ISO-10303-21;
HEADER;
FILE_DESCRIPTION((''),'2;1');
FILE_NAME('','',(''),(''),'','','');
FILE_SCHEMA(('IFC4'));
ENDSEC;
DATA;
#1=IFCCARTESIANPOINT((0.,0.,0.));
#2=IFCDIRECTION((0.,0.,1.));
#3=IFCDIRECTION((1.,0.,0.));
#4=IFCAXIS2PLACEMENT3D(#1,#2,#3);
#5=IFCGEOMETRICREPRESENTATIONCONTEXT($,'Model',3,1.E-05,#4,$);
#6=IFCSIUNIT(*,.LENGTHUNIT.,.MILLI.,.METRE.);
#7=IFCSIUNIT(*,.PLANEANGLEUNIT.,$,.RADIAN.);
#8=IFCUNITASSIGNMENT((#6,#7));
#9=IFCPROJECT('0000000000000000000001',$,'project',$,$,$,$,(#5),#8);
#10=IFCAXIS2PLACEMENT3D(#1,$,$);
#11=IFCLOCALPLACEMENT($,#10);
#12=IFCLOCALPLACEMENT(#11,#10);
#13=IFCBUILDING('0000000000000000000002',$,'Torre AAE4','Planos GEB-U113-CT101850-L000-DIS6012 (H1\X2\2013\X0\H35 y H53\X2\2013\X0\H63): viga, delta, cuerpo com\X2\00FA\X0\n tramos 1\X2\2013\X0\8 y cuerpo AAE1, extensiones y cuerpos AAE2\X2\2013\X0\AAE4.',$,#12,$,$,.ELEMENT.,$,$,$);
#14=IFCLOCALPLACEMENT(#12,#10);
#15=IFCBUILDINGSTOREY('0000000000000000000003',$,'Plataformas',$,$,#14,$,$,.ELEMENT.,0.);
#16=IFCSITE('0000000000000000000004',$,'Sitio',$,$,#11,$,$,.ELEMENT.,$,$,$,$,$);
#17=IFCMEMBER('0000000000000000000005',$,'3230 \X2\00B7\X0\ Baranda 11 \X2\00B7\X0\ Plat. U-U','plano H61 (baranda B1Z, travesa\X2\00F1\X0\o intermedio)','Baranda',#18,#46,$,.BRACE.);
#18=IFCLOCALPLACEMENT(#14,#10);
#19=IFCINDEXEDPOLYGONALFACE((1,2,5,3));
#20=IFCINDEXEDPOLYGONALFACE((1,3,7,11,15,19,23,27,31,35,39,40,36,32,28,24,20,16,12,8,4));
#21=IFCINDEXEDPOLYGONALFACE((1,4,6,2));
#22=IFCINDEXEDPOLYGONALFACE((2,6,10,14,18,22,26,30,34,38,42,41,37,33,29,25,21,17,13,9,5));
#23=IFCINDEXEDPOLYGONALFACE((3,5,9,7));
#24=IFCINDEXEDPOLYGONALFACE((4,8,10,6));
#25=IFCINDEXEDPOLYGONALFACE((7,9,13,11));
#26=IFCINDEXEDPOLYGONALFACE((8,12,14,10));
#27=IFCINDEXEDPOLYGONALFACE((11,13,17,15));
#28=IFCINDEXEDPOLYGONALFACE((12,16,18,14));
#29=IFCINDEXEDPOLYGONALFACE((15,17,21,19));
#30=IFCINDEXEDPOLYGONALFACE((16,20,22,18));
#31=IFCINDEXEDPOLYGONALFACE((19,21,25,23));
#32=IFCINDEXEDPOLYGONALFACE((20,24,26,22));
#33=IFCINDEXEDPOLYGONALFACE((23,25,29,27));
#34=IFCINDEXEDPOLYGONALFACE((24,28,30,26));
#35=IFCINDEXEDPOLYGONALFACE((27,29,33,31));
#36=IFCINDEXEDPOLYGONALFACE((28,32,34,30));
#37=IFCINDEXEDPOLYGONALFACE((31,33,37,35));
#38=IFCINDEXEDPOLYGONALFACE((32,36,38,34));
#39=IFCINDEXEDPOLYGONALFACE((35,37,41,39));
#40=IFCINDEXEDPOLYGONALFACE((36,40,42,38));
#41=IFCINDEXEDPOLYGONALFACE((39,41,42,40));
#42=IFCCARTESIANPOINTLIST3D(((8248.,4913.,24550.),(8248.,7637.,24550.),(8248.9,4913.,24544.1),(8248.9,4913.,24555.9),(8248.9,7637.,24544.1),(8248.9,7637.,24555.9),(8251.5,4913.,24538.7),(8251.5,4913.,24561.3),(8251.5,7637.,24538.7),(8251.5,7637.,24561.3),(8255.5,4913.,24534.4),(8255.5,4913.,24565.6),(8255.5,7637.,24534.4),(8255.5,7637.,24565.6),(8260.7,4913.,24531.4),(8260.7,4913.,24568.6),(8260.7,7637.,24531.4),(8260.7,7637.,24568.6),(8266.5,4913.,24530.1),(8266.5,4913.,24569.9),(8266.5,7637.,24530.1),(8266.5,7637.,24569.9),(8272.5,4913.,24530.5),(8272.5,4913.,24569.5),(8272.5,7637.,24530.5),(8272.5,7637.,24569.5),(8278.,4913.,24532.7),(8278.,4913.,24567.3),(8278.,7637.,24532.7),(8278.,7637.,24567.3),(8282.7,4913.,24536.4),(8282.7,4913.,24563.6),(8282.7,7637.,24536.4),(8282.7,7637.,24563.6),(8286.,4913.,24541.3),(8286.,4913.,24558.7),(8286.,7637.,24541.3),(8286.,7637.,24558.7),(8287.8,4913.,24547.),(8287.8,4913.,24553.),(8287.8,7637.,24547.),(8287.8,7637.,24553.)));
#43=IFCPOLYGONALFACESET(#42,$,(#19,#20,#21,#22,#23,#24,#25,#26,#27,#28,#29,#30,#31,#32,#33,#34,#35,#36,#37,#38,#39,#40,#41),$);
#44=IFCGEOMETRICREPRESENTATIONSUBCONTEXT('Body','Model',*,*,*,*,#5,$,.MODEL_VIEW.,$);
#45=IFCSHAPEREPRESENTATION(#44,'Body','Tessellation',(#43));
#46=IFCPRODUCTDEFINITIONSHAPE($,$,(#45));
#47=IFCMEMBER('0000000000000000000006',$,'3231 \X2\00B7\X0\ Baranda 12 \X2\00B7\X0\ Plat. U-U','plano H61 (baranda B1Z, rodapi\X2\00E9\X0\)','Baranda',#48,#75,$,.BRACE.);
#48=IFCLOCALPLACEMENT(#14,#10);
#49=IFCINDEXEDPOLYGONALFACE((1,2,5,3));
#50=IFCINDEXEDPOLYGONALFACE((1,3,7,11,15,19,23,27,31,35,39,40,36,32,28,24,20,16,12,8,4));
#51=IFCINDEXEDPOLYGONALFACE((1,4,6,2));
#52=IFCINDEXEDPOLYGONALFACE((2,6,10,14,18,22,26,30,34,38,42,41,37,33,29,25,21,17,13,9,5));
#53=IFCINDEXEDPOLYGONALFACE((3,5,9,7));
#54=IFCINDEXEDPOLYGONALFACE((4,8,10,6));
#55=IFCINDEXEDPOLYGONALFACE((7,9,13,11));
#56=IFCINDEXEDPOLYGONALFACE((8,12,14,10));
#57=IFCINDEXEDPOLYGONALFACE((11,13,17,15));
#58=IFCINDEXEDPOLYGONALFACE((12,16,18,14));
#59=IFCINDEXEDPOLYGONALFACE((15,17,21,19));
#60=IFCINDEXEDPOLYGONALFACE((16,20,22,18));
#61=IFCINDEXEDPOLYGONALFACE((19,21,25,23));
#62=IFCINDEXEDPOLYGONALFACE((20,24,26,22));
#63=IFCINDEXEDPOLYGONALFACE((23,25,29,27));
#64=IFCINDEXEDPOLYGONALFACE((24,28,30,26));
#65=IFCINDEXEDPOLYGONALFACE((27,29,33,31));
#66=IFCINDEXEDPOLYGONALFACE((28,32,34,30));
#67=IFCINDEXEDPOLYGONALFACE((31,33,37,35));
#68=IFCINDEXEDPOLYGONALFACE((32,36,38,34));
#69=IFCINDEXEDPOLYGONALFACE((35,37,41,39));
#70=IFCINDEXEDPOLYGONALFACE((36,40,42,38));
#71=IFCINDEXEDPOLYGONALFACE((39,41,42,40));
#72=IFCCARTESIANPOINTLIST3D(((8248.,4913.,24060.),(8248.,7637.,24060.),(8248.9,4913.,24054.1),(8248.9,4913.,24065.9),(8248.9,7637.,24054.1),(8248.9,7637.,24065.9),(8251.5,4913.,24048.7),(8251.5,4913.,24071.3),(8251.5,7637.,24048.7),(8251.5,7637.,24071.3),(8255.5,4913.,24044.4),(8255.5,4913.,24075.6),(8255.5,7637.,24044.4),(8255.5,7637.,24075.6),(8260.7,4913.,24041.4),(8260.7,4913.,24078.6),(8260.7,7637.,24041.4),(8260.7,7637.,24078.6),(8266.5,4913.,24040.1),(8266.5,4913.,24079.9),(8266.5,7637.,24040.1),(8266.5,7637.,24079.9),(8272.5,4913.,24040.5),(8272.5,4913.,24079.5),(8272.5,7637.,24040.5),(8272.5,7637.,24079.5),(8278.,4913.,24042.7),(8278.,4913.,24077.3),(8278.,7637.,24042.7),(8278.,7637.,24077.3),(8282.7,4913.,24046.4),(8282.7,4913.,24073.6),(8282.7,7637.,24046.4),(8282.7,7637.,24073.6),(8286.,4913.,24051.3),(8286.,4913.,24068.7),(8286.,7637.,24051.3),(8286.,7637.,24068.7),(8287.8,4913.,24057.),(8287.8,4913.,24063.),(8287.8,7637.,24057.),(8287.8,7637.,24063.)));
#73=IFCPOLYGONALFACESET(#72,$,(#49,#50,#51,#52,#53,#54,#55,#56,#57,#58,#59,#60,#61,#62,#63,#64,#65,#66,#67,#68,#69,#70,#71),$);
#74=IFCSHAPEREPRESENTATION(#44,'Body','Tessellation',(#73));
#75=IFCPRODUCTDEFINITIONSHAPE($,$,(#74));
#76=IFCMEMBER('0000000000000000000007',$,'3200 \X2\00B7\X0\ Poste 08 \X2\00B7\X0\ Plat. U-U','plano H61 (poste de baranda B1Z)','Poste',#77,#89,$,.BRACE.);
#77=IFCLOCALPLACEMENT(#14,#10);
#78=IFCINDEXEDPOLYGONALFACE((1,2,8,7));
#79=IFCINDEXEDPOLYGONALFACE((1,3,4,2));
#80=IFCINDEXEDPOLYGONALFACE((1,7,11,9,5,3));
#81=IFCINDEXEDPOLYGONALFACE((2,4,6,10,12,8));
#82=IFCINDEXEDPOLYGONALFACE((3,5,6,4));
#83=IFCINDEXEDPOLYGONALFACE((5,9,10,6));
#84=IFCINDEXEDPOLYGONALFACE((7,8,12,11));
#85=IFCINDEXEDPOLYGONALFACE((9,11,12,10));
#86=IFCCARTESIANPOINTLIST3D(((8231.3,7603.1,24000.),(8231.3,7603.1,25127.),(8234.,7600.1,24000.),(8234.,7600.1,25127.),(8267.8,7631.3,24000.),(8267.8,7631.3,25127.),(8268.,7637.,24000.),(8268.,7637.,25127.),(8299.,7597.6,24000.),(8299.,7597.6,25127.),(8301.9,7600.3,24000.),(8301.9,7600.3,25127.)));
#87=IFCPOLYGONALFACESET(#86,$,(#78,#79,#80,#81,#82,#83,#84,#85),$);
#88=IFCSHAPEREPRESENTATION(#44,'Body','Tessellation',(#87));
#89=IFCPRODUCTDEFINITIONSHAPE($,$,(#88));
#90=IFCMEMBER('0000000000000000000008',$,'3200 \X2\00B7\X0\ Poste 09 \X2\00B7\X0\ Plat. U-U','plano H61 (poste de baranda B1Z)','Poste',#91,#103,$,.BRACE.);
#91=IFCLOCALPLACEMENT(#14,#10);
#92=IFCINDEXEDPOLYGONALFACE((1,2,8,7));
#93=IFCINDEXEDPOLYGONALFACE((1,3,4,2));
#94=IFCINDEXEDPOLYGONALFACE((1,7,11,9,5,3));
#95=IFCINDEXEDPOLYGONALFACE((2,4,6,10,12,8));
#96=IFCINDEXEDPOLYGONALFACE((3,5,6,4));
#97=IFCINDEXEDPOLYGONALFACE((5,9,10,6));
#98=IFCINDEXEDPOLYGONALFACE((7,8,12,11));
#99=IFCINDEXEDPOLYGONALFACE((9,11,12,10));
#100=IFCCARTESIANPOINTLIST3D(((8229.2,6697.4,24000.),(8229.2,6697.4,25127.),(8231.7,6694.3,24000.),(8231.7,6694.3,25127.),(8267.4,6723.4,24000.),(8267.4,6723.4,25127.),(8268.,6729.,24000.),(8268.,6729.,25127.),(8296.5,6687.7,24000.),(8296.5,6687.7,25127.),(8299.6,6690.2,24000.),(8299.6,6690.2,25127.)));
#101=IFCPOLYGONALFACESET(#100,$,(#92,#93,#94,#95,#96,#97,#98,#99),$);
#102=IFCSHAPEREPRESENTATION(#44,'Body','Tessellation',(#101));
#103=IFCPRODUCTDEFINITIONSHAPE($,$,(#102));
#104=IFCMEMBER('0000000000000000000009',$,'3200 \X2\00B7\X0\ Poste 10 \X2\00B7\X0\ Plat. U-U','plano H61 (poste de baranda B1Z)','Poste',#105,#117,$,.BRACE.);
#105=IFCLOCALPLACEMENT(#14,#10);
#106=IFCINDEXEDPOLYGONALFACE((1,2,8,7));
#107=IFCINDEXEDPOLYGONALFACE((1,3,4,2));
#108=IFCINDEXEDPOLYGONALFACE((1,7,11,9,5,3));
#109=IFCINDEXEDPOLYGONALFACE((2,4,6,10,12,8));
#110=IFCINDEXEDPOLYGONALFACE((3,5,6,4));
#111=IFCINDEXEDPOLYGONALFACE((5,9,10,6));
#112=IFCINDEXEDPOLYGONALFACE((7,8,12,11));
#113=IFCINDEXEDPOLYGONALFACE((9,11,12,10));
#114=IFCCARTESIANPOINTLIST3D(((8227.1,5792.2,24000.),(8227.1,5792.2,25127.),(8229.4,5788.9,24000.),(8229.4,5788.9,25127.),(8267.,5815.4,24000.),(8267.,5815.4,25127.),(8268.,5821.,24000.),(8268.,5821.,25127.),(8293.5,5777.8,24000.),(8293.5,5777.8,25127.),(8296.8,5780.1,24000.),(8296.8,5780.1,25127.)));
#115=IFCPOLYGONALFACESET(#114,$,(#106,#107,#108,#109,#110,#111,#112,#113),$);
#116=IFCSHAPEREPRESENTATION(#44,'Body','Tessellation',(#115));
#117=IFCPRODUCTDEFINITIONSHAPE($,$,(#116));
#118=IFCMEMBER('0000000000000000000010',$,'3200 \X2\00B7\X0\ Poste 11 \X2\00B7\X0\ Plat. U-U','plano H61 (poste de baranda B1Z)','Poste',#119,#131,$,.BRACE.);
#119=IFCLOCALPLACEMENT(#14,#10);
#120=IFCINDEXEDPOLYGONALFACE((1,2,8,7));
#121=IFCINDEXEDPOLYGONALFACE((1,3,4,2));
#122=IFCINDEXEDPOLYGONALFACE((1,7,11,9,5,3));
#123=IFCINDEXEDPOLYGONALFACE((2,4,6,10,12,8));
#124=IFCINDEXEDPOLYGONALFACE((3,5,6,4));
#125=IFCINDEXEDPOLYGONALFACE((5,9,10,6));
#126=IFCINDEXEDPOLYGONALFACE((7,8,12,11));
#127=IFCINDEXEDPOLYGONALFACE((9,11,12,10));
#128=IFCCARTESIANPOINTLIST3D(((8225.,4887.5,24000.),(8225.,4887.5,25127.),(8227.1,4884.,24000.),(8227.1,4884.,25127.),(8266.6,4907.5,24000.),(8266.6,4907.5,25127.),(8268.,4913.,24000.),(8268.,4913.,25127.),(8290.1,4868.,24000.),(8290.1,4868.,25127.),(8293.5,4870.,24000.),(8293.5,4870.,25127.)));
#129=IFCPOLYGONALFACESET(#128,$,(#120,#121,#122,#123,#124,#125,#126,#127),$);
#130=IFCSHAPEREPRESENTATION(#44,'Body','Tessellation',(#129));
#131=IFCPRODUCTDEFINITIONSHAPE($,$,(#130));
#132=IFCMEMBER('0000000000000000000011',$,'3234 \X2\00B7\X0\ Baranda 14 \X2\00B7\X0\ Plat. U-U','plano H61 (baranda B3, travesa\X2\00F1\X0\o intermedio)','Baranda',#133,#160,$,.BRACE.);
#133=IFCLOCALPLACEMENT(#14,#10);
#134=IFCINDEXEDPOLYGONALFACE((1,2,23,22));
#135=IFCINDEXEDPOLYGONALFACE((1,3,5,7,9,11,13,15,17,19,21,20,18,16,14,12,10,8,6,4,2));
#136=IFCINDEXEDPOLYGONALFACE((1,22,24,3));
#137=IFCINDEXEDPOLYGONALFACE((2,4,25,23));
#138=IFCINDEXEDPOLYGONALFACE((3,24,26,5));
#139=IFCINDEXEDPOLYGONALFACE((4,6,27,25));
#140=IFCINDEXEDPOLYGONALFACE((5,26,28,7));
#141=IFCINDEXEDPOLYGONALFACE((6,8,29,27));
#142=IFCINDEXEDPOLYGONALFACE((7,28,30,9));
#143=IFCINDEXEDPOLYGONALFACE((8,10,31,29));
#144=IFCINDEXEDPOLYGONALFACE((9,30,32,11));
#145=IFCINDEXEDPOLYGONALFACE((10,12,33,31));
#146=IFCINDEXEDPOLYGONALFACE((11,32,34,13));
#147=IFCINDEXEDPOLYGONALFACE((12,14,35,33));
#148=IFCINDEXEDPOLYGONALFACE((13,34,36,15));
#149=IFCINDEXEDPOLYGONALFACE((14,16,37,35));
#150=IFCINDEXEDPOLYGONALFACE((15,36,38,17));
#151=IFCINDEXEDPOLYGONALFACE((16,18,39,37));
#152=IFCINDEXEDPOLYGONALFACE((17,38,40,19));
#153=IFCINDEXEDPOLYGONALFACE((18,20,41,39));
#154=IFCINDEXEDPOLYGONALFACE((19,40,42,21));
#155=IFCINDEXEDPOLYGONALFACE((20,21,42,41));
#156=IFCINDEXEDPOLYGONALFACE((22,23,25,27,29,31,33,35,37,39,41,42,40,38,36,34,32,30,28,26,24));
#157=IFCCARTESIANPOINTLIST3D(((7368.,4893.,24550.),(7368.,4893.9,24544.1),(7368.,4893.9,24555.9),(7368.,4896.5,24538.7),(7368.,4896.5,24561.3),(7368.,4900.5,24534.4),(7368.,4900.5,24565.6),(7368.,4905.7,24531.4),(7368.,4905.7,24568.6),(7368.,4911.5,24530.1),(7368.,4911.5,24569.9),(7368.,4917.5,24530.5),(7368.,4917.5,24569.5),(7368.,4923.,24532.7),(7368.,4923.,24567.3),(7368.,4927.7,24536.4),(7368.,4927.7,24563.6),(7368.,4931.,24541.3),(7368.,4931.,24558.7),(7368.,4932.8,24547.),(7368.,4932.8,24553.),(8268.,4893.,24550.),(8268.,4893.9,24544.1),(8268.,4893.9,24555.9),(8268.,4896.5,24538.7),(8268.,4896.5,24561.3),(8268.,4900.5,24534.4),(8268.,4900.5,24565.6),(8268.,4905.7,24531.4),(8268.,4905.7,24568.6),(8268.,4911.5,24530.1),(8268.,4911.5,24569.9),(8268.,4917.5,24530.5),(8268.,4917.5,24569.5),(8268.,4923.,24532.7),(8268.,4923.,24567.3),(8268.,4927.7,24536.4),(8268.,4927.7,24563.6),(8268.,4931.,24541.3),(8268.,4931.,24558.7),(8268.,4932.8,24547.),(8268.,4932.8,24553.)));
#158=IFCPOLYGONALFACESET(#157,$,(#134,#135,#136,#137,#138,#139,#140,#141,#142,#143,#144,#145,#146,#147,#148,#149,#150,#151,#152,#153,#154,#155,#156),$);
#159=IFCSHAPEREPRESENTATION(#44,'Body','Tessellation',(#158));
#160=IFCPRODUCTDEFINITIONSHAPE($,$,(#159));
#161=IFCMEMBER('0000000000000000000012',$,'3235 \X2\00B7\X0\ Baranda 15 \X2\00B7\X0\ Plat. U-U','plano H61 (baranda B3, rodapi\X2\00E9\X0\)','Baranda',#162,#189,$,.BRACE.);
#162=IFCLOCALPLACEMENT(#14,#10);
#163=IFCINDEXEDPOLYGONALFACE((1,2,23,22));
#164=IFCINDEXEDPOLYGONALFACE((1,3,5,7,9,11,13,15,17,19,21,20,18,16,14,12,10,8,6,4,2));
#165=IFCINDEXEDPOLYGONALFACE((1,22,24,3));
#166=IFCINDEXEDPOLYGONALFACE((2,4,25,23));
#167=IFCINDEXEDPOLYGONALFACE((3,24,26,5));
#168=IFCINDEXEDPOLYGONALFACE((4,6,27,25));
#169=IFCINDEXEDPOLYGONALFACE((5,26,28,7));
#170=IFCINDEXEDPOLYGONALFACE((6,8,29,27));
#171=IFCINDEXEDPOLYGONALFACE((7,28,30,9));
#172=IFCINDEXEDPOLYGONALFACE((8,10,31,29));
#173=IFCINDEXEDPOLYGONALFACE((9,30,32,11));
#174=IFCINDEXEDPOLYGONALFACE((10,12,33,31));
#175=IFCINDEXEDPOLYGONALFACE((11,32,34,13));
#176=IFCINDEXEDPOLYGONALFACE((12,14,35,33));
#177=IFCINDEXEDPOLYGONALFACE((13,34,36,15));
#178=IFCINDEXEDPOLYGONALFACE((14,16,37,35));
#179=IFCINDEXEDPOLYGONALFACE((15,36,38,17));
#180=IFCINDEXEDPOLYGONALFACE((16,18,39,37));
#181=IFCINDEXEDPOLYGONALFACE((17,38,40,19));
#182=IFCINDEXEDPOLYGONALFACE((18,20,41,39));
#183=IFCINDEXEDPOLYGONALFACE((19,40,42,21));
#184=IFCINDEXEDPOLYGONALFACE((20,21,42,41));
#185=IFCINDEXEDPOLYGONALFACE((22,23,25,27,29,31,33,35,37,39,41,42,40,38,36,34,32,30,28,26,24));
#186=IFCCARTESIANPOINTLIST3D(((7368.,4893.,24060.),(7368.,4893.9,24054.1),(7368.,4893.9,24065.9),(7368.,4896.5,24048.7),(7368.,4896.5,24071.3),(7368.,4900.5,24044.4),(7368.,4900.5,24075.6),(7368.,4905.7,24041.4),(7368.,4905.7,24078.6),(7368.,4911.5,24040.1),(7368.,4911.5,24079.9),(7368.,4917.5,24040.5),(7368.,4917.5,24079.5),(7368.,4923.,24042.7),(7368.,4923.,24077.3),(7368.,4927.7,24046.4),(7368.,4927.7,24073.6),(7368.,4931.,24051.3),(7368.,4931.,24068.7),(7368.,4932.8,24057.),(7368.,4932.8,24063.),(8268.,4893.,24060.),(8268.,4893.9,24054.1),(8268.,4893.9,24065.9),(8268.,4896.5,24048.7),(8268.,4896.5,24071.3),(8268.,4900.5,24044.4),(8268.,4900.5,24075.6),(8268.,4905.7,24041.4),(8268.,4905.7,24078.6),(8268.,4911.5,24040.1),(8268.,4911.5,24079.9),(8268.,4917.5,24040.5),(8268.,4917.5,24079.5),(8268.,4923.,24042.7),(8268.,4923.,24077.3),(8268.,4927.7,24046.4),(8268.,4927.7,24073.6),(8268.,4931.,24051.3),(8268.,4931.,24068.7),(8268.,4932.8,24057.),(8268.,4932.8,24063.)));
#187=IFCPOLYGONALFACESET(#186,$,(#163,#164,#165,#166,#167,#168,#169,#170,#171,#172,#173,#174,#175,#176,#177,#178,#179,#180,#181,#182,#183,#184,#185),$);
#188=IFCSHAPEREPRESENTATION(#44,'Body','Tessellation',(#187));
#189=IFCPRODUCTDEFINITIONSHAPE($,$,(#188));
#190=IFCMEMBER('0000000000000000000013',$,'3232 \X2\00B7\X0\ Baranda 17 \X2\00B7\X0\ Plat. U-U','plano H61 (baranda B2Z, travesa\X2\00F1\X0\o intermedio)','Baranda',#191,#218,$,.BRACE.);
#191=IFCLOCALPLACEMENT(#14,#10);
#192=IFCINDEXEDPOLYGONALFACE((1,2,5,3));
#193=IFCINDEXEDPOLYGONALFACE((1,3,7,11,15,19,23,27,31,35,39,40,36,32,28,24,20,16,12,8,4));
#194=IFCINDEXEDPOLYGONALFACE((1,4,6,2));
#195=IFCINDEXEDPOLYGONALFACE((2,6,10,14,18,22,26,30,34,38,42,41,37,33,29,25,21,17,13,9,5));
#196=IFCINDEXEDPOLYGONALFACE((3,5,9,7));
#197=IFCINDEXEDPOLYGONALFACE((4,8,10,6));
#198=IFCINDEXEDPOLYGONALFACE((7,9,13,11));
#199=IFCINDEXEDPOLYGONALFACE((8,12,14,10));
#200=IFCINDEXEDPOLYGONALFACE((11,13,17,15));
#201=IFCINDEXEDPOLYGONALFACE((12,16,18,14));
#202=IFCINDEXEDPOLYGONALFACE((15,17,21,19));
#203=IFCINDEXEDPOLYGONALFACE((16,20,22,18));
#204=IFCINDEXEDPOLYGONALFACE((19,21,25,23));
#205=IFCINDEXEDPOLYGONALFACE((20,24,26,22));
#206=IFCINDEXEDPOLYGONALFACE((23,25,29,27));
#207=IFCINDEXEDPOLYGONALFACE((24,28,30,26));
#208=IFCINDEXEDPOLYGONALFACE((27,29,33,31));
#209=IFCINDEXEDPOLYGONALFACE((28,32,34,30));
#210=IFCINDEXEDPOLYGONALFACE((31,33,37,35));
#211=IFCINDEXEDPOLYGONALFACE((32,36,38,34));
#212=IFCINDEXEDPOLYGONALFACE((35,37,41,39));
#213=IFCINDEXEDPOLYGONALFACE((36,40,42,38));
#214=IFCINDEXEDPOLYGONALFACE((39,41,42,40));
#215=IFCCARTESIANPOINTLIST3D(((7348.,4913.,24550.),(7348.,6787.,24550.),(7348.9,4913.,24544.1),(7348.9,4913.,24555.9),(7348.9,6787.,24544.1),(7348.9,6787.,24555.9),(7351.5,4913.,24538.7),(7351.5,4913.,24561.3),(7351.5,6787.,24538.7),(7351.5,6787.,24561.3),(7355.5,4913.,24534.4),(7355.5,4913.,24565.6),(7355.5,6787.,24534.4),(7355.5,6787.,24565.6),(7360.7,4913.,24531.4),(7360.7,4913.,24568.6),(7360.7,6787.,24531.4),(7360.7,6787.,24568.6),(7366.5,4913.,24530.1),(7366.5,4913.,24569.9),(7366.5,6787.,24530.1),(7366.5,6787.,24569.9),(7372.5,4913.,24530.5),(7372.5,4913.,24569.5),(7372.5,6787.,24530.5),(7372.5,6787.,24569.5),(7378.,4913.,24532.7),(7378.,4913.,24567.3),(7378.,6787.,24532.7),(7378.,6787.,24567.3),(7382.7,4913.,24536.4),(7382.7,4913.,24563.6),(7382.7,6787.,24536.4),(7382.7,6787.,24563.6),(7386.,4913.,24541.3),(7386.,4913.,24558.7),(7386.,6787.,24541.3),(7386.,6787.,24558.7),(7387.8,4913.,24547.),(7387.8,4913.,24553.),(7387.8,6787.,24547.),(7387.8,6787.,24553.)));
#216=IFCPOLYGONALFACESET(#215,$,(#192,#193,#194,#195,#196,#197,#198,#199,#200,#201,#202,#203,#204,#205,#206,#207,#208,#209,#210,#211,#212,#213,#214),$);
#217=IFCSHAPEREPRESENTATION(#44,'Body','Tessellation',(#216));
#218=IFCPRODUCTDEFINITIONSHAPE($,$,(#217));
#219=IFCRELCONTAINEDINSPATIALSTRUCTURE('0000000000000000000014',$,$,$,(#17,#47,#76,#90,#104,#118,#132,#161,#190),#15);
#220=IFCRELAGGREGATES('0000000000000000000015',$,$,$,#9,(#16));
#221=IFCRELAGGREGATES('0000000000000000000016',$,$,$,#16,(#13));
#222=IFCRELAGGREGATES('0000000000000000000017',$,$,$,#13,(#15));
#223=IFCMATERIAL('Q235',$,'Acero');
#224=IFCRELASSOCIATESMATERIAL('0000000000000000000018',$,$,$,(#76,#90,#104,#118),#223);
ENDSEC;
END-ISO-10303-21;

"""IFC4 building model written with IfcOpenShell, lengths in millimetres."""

from ifc_helpers import new_model, si_unit, frame, frame_2d, origin, origin_with_axes, place, context, subcontext, project, spatial, circle, l_section, extrude, material, element, save


model = new_model("IFC4")

# Units and contexts
model_context = context("Model", 3, precision=1e-05, world=origin_with_axes())
body_context = subcontext(model_context, "Body", "Model", "MODEL_VIEW")
ifc_project = project(units=[si_unit("LENGTHUNIT", "METRE", prefix="MILLI"), si_unit("PLANEANGLEUNIT", "RADIAN")], contexts=[model_context])

# Site, building, storey
site_placement = place(None, origin())
site = spatial("IfcSite", under=ifc_project, at=site_placement, Name="Sitio", CompositionType="ELEMENT")
building_placement = place(site_placement, origin())
building = spatial("IfcBuilding", under=site, at=building_placement, Name="Torre AAE4", Description="Planos GEB-U113-CT101850-L000-DIS6012 (H1–H35 y H53–H63): viga, delta, cuerpo común tramos 1–8 y cuerpo AAE1, extensiones y cuerpos AAE2–AAE4.", CompositionType="ELEMENT")
storey_placement = place(building_placement, origin())
storey = spatial("IfcBuildingStorey", under=building, at=storey_placement, Name="Plataformas", CompositionType="ELEMENT", Elevation=0.0)

# Members
ifc_material = material(Name="Q235", Category="Acero")
for number, where, z_axis, x_axis, name, description in (
    (1, (8268.0, 7637.0, 24550.0), (0.0, -1.0, 0.0), (-1.0, 0.0, 0.0), "3230 · Baranda 11 · Plat. U-U", "plano H61 (baranda B1Z, travesaño intermedio)"),
    (2, (8268.0, 7637.0, 24060.0), (0.0, -1.0, 0.0), (-1.0, 0.0, 0.0), "3231 · Baranda 12 · Plat. U-U", "plano H61 (baranda B1Z, rodapié)"),
):
    element("IfcMember", number, at=place(storey_placement, frame(where, z_axis=z_axis, x_axis=x_axis)), inside=storey, Name=name, Description=description, ObjectType="Baranda", PredefinedType="BRACE", context=body_context, shape_type="SweptSolid", body=[
        extrude(circle(Radius=20.0), None, (0.0, 0.0, 1.0), 2724.0),
    ])
for number, where, z_axis, x_axis, name in (
    (3, (8268.0, 7637.0, 24000.0), (0.0, 0.0, 1.0), (-0.734582, -0.67852, 0.0), "3200 · Poste 08 · Plat. U-U"),
    (4, (8268.0, 6729.0, 24000.0), (0.0, 0.0, 1.0), (-0.775597, -0.631228, 0.0), "3200 · Poste 09 · Plat. U-U"),
    (5, (8268.0, 5821.0, 24000.0), (0.0, 0.0, 1.0), (-0.817677, -0.575677, 0.0), "3200 · Poste 10 · Plat. U-U"),
    (6, (8268.0, 4913.0, 24000.0), (0.0, 0.0, 1.0), (-0.859678, -0.510837, 0.0), "3200 · Poste 11 · Plat. U-U"),
):
    element("IfcMember", number, at=place(storey_placement, frame(where, z_axis=z_axis, x_axis=x_axis)), inside=storey, material=ifc_material, Name=name, Description="plano H61 (poste de baranda B1Z)", ObjectType="Poste", PredefinedType="BRACE", context=body_context, shape_type="SweptSolid", body=[
        extrude(l_section(Depth=50.0, Width=50.0, Thickness=4.0, at=frame_2d((25.0, 25.0))), None, (0.0, 0.0, 1.0), 1127.0),
    ])
for number, where, z_axis, x_axis, name, description in (
    (7, (8268.0, 4913.0, 24550.0), (-1.0, 0.0, 0.0), (0.0, -1.0, 0.0), "3234 · Baranda 14 · Plat. U-U", "plano H61 (baranda B3, travesaño intermedio)"),
    (8, (8268.0, 4913.0, 24060.0), (-1.0, 0.0, 0.0), (0.0, -1.0, 0.0), "3235 · Baranda 15 · Plat. U-U", "plano H61 (baranda B3, rodapié)"),
):
    element("IfcMember", number, at=place(storey_placement, frame(where, z_axis=z_axis, x_axis=x_axis)), inside=storey, Name=name, Description=description, ObjectType="Baranda", PredefinedType="BRACE", context=body_context, shape_type="SweptSolid", body=[
        extrude(circle(Radius=20.0), None, (0.0, 0.0, 1.0), 900.0),
    ])
member_1_placement = place(storey_placement, frame((7368.0, 4913.0, 24550.0), z_axis=(0.0, 1.0, 0.0), x_axis=(-1.0, 0.0, 0.0)))
element("IfcMember", 9, at=member_1_placement, inside=storey, Name="3232 · Baranda 17 · Plat. U-U", Description="plano H61 (baranda B2Z, travesaño intermedio)", ObjectType="Baranda", PredefinedType="BRACE", context=body_context, shape_type="SweptSolid", body=[
    extrude(circle(Radius=20.0), None, (0.0, 0.0, 1.0), 1874.0),
])

save(model, "model.ifc")
